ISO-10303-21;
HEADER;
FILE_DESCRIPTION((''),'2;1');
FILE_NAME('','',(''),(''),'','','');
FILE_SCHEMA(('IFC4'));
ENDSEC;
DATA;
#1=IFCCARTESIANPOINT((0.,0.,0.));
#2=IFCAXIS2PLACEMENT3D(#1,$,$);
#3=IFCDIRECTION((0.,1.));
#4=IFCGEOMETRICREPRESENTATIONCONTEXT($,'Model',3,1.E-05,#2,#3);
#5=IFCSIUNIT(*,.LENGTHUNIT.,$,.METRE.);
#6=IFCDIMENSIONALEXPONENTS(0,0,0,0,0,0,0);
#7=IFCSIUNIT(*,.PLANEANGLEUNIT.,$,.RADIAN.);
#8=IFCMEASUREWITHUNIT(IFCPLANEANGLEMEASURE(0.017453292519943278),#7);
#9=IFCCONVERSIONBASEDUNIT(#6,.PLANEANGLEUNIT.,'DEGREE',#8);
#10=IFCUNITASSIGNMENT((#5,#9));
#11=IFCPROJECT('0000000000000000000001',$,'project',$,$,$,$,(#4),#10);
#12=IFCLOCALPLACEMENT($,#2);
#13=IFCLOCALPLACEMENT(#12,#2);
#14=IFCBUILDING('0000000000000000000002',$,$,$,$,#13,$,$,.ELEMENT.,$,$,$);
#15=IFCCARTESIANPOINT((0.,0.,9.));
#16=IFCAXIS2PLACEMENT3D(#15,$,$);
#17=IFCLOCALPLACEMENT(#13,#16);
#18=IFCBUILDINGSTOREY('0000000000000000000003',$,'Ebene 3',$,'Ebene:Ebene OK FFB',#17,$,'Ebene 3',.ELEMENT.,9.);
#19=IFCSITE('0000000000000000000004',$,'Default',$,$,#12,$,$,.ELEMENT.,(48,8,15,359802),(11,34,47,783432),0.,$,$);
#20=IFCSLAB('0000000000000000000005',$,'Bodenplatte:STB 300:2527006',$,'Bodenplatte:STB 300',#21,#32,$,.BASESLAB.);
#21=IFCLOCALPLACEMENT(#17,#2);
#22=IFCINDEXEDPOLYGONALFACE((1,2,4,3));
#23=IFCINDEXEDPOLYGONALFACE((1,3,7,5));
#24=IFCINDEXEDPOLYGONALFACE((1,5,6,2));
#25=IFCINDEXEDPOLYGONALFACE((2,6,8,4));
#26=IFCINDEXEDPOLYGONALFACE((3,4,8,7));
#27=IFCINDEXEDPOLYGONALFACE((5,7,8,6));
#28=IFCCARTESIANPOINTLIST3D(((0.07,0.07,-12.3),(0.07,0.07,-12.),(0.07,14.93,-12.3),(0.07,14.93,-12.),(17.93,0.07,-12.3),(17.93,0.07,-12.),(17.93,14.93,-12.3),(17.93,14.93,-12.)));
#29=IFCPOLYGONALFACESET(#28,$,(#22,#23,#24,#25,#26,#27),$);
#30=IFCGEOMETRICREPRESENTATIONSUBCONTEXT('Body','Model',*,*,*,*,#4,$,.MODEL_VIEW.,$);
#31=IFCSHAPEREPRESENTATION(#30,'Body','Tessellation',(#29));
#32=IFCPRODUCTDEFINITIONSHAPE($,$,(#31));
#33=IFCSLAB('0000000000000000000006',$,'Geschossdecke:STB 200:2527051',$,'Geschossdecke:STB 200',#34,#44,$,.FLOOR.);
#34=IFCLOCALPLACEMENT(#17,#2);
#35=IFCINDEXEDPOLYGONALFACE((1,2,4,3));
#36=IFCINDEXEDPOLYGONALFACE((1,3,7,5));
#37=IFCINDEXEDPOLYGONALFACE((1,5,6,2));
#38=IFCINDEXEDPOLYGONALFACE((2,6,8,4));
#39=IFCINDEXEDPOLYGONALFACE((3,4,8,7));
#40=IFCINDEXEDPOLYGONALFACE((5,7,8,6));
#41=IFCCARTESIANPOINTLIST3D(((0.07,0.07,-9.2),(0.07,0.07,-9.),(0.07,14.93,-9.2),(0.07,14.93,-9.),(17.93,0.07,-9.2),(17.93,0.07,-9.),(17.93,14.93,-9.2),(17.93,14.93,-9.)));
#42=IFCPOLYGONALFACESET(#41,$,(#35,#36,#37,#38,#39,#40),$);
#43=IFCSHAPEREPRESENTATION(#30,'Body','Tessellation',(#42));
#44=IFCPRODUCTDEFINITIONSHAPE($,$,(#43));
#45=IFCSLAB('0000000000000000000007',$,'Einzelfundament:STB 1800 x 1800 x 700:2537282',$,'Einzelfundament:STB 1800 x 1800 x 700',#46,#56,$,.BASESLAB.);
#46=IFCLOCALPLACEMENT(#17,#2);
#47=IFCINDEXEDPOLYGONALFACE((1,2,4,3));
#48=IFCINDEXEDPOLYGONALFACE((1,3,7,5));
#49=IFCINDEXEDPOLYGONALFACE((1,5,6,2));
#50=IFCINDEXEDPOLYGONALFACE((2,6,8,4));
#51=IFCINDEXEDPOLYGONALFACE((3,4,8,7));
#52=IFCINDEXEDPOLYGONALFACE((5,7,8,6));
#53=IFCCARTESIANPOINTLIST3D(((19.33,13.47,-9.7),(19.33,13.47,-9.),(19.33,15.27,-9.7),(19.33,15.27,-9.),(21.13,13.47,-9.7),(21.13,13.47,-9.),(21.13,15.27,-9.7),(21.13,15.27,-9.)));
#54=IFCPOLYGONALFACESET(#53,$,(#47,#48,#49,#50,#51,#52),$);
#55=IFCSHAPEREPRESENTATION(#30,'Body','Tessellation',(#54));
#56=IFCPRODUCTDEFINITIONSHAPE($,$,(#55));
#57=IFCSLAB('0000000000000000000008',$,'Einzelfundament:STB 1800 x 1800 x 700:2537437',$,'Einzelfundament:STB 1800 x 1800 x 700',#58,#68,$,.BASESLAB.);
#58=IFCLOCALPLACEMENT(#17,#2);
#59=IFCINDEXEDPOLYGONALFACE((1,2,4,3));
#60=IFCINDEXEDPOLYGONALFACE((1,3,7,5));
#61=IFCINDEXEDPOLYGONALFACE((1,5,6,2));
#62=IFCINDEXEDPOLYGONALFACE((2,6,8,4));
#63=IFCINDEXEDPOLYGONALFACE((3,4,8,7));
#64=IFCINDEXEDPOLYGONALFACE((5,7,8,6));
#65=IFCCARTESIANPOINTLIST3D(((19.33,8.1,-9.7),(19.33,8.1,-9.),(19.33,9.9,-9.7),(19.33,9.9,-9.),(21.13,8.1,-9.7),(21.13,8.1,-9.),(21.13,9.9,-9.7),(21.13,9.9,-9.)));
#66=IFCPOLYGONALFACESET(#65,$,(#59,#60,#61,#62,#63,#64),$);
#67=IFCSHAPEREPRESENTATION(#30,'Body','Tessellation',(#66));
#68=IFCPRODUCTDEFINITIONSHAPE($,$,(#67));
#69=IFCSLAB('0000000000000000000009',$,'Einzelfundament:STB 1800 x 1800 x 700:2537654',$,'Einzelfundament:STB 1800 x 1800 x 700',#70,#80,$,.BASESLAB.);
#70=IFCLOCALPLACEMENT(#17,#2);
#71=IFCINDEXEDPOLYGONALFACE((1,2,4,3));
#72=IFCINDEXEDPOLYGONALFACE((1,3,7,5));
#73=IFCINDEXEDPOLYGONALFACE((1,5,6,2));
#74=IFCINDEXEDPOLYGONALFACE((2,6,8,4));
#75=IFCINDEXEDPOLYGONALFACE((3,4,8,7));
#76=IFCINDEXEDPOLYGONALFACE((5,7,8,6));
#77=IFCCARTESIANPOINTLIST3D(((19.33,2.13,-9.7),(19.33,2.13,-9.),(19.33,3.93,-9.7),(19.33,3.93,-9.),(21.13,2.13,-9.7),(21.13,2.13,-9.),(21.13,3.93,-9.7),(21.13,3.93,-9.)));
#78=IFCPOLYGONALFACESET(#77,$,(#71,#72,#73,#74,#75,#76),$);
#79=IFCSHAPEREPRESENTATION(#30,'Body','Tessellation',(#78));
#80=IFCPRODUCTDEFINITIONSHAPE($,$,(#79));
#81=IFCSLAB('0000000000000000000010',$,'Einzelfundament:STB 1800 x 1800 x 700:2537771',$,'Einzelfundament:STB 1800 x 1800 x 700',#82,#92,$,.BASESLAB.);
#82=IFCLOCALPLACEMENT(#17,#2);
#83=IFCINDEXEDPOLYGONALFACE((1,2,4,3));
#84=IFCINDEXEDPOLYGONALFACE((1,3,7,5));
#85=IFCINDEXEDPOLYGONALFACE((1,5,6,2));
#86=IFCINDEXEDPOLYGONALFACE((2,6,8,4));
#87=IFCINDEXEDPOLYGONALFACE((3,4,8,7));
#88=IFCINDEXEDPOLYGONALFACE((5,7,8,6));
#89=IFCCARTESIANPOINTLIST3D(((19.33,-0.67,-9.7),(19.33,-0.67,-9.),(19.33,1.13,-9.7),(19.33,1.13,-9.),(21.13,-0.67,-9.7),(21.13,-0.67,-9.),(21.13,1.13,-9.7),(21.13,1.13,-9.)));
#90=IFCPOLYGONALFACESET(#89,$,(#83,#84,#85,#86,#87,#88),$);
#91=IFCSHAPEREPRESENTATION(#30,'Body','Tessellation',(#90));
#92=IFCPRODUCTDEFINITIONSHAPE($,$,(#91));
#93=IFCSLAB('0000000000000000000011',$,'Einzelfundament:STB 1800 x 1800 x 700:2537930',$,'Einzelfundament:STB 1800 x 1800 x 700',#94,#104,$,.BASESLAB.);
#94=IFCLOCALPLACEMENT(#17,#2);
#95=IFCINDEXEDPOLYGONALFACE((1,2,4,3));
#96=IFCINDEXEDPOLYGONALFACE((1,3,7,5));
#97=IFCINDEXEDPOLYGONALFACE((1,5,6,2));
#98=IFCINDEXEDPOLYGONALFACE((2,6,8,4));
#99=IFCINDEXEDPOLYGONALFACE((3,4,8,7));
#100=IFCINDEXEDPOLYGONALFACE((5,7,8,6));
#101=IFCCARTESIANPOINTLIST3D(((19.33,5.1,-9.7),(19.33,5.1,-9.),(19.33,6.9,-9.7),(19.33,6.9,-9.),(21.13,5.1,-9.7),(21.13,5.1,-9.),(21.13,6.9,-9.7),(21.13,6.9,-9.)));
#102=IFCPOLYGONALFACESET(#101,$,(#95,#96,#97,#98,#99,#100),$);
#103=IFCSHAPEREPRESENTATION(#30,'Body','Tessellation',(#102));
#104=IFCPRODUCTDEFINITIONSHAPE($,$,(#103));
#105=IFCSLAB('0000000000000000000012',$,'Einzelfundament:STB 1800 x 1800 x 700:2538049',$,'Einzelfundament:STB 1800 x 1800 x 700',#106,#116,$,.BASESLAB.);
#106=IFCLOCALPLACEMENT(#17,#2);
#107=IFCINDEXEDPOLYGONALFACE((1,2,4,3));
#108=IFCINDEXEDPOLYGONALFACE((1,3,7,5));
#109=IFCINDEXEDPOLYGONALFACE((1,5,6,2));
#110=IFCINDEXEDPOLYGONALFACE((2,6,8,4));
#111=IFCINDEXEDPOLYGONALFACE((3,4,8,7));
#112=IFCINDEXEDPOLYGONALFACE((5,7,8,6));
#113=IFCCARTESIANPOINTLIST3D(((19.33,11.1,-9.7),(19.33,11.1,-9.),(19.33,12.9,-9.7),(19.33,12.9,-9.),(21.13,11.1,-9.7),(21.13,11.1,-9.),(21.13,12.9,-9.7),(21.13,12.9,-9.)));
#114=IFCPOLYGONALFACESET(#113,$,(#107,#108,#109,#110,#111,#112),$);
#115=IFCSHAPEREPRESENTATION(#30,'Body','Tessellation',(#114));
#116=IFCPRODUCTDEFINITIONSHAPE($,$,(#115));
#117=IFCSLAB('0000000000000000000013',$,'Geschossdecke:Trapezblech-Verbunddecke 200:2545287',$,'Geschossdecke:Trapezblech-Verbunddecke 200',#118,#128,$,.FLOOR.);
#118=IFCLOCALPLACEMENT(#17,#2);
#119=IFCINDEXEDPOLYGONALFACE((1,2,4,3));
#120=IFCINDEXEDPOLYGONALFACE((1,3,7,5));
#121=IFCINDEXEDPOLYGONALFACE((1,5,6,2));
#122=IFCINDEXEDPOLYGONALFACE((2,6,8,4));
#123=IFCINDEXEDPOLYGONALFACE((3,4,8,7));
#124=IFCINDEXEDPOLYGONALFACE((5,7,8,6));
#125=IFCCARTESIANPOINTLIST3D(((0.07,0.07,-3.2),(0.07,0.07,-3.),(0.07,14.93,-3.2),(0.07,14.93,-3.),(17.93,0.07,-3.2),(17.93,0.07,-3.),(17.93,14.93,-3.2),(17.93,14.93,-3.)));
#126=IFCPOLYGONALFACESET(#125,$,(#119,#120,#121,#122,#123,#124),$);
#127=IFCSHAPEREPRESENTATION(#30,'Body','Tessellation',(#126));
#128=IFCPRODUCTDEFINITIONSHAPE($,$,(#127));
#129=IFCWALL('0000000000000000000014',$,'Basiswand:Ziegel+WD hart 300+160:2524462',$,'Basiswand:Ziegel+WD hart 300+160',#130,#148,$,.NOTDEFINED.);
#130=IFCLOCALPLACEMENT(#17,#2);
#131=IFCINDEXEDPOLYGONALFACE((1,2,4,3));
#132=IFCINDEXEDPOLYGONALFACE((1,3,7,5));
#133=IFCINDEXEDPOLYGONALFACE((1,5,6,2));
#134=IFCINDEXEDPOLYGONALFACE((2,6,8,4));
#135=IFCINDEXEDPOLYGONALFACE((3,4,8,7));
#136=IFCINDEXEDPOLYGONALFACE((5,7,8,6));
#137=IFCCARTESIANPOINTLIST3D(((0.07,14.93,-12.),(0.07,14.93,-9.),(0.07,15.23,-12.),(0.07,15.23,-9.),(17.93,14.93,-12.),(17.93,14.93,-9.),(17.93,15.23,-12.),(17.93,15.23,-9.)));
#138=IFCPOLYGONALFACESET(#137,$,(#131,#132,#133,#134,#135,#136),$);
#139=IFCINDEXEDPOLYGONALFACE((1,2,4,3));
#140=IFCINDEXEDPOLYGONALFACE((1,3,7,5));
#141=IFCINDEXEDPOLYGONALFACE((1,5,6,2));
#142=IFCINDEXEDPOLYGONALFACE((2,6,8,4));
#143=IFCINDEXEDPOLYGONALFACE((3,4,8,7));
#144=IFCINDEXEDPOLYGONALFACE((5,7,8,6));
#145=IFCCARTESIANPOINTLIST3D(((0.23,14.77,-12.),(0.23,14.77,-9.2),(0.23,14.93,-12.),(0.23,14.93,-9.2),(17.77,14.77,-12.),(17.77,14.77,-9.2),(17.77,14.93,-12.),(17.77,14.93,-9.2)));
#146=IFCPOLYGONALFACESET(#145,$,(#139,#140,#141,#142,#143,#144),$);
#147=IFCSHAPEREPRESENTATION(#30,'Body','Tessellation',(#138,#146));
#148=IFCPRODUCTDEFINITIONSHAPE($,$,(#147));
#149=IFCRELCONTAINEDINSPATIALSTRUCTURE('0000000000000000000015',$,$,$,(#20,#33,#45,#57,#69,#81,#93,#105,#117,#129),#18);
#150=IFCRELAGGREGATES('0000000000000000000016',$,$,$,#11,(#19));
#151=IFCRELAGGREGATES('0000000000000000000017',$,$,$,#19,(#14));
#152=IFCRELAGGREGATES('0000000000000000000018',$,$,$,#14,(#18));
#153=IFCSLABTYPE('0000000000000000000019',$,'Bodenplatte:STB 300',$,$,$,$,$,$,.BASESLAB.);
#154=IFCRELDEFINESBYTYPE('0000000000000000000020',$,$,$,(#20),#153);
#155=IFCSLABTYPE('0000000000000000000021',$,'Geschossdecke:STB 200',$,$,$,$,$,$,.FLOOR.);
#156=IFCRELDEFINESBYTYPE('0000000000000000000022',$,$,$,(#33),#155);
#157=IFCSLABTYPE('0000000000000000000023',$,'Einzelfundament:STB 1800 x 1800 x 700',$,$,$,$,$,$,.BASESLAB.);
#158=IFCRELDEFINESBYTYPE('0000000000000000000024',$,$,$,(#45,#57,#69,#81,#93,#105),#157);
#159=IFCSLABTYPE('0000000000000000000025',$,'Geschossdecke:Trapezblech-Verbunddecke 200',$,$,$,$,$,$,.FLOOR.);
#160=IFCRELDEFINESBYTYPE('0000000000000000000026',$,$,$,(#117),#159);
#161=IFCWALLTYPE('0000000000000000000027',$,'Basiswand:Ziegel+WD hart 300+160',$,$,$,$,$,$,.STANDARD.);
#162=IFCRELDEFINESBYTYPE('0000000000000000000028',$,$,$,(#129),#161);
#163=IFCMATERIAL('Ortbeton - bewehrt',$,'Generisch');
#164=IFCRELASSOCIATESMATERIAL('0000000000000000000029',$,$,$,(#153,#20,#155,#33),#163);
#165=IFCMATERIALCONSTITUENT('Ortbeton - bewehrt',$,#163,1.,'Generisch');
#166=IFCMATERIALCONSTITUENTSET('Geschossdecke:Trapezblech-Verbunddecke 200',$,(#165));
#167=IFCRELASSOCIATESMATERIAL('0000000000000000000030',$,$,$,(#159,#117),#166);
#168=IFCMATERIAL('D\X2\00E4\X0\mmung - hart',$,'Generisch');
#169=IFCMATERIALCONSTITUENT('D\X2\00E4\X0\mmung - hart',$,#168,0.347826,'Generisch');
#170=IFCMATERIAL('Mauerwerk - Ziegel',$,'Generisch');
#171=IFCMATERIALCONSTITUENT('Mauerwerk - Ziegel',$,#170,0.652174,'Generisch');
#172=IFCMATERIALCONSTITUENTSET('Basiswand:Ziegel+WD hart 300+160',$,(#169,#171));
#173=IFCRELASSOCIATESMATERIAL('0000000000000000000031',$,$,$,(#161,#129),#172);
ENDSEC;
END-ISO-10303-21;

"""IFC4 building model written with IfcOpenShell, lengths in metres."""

from ifc_helpers import new_model, entity, si_unit, converted_unit, direction, frame, origin, place, context, subcontext, project, spatial, indexed_curve, outline, extrude, material, constituent, constituent_set, type_object, element, save


model = new_model("IFC4")

# Units and contexts
model_context = context("Model", 3, precision=1e-05, world=origin(), true_north=direction((0.0, 1.0)))
body_context = subcontext(model_context, "Body", "Model", "MODEL_VIEW")
ifc_project = project(units=[si_unit("LENGTHUNIT", "METRE"), converted_unit("PLANEANGLEUNIT", "DEGREE", entity("IfcPlaneAngleMeasure", 0.017453292519943278), si_unit("PLANEANGLEUNIT", "RADIAN"), dimensions=[0, 0, 0, 0, 0, 0, 0])], contexts=[model_context])

# Site, building, storey
site_placement = place(None, origin())
site = spatial("IfcSite", under=ifc_project, at=site_placement, Name="Default", CompositionType="ELEMENT", RefLatitude=(48, 8, 15, 359802), RefLongitude=(11, 34, 47, 783432), RefElevation=0.0)
building_placement = place(site_placement, origin())
building = spatial("IfcBuilding", under=site, at=building_placement, CompositionType="ELEMENT")
storey_placement = place(building_placement, frame((0.0, 0.0, 9.0)))
storey = spatial("IfcBuildingStorey", under=building, at=storey_placement, Name="Ebene 3", ObjectType="Ebene:Ebene OK FFB", LongName="Ebene 3", CompositionType="ELEMENT", Elevation=9.0)

# Slabs
ifc_material_1 = material(Name="Ortbeton - bewehrt", Category="Generisch")
slab_type_1 = type_object("IfcSlabType", Name="Bodenplatte:STB 300", PredefinedType="BASESLAB", material=ifc_material_1)
slab_1_placement = place(storey_placement, origin())
element("IfcSlab", 1, at=slab_1_placement, inside=storey, type_object=slab_type_1, material=ifc_material_1, Name="Bodenplatte:STB 300:2527006", ObjectType="Bodenplatte:STB 300", PredefinedType="BASESLAB", context=body_context, shape_type="SweptSolid", body=[
    extrude(outline(indexed_curve([(-7.43, -8.93), (7.43, -8.93), (7.43, 8.93), (-7.43, 8.93), (-7.43, -8.93)], self_intersect=False)), frame((9.0, 7.5, -12.0), z_axis=(0.0, 0.0, -1.0), x_axis=(0.0, 1.0, 0.0)), (0.0, 0.0, 1.0), 0.3),
])
slab_type_2 = type_object("IfcSlabType", Name="Geschossdecke:STB 200", PredefinedType="FLOOR", material=ifc_material_1)
slab_2_placement = place(storey_placement, origin())
element("IfcSlab", 2, at=slab_2_placement, inside=storey, type_object=slab_type_2, material=ifc_material_1, Name="Geschossdecke:STB 200:2527051", ObjectType="Geschossdecke:STB 200", PredefinedType="FLOOR", context=body_context, shape_type="SweptSolid", body=[
    extrude(outline(indexed_curve([(-7.43, -8.93), (7.43, -8.93), (7.43, 8.93), (-7.43, 8.93), (-7.43, -8.93)], self_intersect=False)), frame((9.0, 7.5, -9.0), z_axis=(0.0, 0.0, -1.0), x_axis=(0.0, 1.0, 0.0)), (0.0, 0.0, 1.0), 0.2),
])

# Slabs
slab_type_3 = type_object("IfcSlabType", Name="Einzelfundament:STB 1800 x 1800 x 700", PredefinedType="BASESLAB")
slab_3_placement = place(storey_placement, origin())
element("IfcSlab", 3, at=slab_3_placement, inside=storey, type_object=slab_type_3, Name="Einzelfundament:STB 1800 x 1800 x 700:2537282", ObjectType="Einzelfundament:STB 1800 x 1800 x 700", PredefinedType="BASESLAB", context=body_context, shape_type="SweptSolid", body=[
    extrude(outline(indexed_curve([(-0.9, -0.9), (0.9, -0.9), (0.9, 0.9), (-0.9, 0.9), (-0.9, -0.9)], self_intersect=False)), frame((20.23, 14.37, -9.7), z_axis=(0.0, 0.0, 1.0), x_axis=(-1.0, 0.0, 0.0)), (0.0, 0.0, 1.0), 0.7),
])
slab_4_placement = place(storey_placement, origin())
element("IfcSlab", 4, at=slab_4_placement, inside=storey, type_object=slab_type_3, Name="Einzelfundament:STB 1800 x 1800 x 700:2537437", ObjectType="Einzelfundament:STB 1800 x 1800 x 700", PredefinedType="BASESLAB", context=body_context, shape_type="SweptSolid", body=[
    extrude(outline(indexed_curve([(-0.9, -0.9), (0.9, -0.9), (0.9, 0.9), (-0.9, 0.9), (-0.9, -0.9)], self_intersect=False)), frame((20.23, 9.0, -9.7), z_axis=(0.0, 0.0, 1.0), x_axis=(-1.0, 0.0, 0.0)), (0.0, 0.0, 1.0), 0.7),
])
slab_5_placement = place(storey_placement, origin())
element("IfcSlab", 5, at=slab_5_placement, inside=storey, type_object=slab_type_3, Name="Einzelfundament:STB 1800 x 1800 x 700:2537654", ObjectType="Einzelfundament:STB 1800 x 1800 x 700", PredefinedType="BASESLAB", context=body_context, shape_type="SweptSolid", body=[
    extrude(outline(indexed_curve([(-0.9, -0.9), (0.9, -0.9), (0.9, 0.9), (-0.9, 0.9), (-0.9, -0.9)], self_intersect=False)), frame((20.23, 3.03, -9.7), z_axis=(0.0, 0.0, 1.0), x_axis=(-1.0, 0.0, 0.0)), (0.0, 0.0, 1.0), 0.7),
])
slab_6_placement = place(storey_placement, origin())
element("IfcSlab", 6, at=slab_6_placement, inside=storey, type_object=slab_type_3, Name="Einzelfundament:STB 1800 x 1800 x 700:2537771", ObjectType="Einzelfundament:STB 1800 x 1800 x 700", PredefinedType="BASESLAB", context=body_context, shape_type="SweptSolid", body=[
    extrude(outline(indexed_curve([(-0.9, -0.9), (0.9, -0.9), (0.9, 0.9), (-0.9, 0.9), (-0.9, -0.9)], self_intersect=False)), frame((20.23, 0.23, -9.7), z_axis=(0.0, 0.0, 1.0), x_axis=(-1.0, 0.0, 0.0)), (0.0, 0.0, 1.0), 0.7),
])
slab_7_placement = place(storey_placement, origin())
element("IfcSlab", 7, at=slab_7_placement, inside=storey, type_object=slab_type_3, Name="Einzelfundament:STB 1800 x 1800 x 700:2537930", ObjectType="Einzelfundament:STB 1800 x 1800 x 700", PredefinedType="BASESLAB", context=body_context, shape_type="SweptSolid", body=[
    extrude(outline(indexed_curve([(-0.9, -0.9), (0.9, -0.9), (0.9, 0.9), (-0.9, 0.9), (-0.9, -0.9)], self_intersect=False)), frame((20.23, 6.0, -9.7), z_axis=(0.0, 0.0, 1.0), x_axis=(-1.0, 0.0, 0.0)), (0.0, 0.0, 1.0), 0.7),
])
slab_8_placement = place(storey_placement, origin())
element("IfcSlab", 8, at=slab_8_placement, inside=storey, type_object=slab_type_3, Name="Einzelfundament:STB 1800 x 1800 x 700:2538049", ObjectType="Einzelfundament:STB 1800 x 1800 x 700", PredefinedType="BASESLAB", context=body_context, shape_type="SweptSolid", body=[
    extrude(outline(indexed_curve([(-0.9, -0.9), (0.9, -0.9), (0.9, 0.9), (-0.9, 0.9), (-0.9, -0.9)], self_intersect=False)), frame((20.23, 12.0, -9.7), z_axis=(0.0, 0.0, 1.0), x_axis=(-1.0, 0.0, 0.0)), (0.0, 0.0, 1.0), 0.7),
])
ifc_constituent_1 = constituent(ifc_material_1, Name="Ortbeton - bewehrt", Category="Generisch", fraction=1.0)
ifc_constituent_set_1 = constituent_set(constituents=[ifc_constituent_1], Name="Geschossdecke:Trapezblech-Verbunddecke 200")
slab_type_4 = type_object("IfcSlabType", Name="Geschossdecke:Trapezblech-Verbunddecke 200", PredefinedType="FLOOR", material=ifc_constituent_set_1)
slab_9_placement = place(storey_placement, origin())
element("IfcSlab", 9, at=slab_9_placement, inside=storey, type_object=slab_type_4, material=ifc_constituent_set_1, Name="Geschossdecke:Trapezblech-Verbunddecke 200:2545287", ObjectType="Geschossdecke:Trapezblech-Verbunddecke 200", PredefinedType="FLOOR", context=body_context, shape_type="SweptSolid", body=[
    extrude(outline(indexed_curve([(-7.43, -8.93), (7.43, -8.93), (7.43, 8.93), (-7.43, 8.93), (-7.43, -8.93)], self_intersect=False)), frame((9.0, 7.5, -3.0), z_axis=(0.0, 0.0, -1.0), x_axis=(0.0, 1.0, 0.0)), (0.0, 0.0, 1.0), 0.2),
])

# Wall
ifc_material_2 = material(Name="Dämmung - hart", Category="Generisch")
ifc_constituent_2 = constituent(ifc_material_2, Name="Dämmung - hart", Category="Generisch", fraction=0.347826)
ifc_material_3 = material(Name="Mauerwerk - Ziegel", Category="Generisch")
ifc_constituent_3 = constituent(ifc_material_3, Name="Mauerwerk - Ziegel", Category="Generisch", fraction=0.652174)
ifc_constituent_set_2 = constituent_set(constituents=[ifc_constituent_2, ifc_constituent_3], Name="Basiswand:Ziegel+WD hart 300+160")
wall_type = type_object("IfcWallType", Name="Basiswand:Ziegel+WD hart 300+160", PredefinedType="STANDARD", material=ifc_constituent_set_2)
wall_1_placement = place(storey_placement, frame((17.77, 15.0, -12.0), z_axis=(0.0, 0.0, 1.0), x_axis=(-1.0, 0.0, 0.0)))
element("IfcWall", 10, at=wall_1_placement, inside=storey, type_object=wall_type, material=ifc_constituent_set_2, Name="Basiswand:Ziegel+WD hart 300+160:2524462", ObjectType="Basiswand:Ziegel+WD hart 300+160", PredefinedType="NOTDEFINED", context=body_context, shape_type="SweptSolid", body=[
    extrude(outline(indexed_curve([(-0.15, -8.93), (0.15, -8.93), (0.15, 8.93), (-0.15, 8.93), (-0.15, -8.93)], self_intersect=False)), frame((8.77, -0.08, 0.0), z_axis=(0.0, 0.0, 1.0), x_axis=(0.0, 1.0, 0.0)), (0.0, 0.0, 1.0), 3.0),
    extrude(outline(indexed_curve([(-0.08, -8.77), (0.08, -8.77), (0.08, 8.77), (-0.08, 8.77), (-0.08, -8.77)], self_intersect=False)), frame((8.77, 0.15, 0.0), z_axis=(0.0, 0.0, 1.0), x_axis=(0.0, -1.0, 0.0)), (0.0, 0.0, 1.0), 2.8),
])

save(model, "model.ifc")
